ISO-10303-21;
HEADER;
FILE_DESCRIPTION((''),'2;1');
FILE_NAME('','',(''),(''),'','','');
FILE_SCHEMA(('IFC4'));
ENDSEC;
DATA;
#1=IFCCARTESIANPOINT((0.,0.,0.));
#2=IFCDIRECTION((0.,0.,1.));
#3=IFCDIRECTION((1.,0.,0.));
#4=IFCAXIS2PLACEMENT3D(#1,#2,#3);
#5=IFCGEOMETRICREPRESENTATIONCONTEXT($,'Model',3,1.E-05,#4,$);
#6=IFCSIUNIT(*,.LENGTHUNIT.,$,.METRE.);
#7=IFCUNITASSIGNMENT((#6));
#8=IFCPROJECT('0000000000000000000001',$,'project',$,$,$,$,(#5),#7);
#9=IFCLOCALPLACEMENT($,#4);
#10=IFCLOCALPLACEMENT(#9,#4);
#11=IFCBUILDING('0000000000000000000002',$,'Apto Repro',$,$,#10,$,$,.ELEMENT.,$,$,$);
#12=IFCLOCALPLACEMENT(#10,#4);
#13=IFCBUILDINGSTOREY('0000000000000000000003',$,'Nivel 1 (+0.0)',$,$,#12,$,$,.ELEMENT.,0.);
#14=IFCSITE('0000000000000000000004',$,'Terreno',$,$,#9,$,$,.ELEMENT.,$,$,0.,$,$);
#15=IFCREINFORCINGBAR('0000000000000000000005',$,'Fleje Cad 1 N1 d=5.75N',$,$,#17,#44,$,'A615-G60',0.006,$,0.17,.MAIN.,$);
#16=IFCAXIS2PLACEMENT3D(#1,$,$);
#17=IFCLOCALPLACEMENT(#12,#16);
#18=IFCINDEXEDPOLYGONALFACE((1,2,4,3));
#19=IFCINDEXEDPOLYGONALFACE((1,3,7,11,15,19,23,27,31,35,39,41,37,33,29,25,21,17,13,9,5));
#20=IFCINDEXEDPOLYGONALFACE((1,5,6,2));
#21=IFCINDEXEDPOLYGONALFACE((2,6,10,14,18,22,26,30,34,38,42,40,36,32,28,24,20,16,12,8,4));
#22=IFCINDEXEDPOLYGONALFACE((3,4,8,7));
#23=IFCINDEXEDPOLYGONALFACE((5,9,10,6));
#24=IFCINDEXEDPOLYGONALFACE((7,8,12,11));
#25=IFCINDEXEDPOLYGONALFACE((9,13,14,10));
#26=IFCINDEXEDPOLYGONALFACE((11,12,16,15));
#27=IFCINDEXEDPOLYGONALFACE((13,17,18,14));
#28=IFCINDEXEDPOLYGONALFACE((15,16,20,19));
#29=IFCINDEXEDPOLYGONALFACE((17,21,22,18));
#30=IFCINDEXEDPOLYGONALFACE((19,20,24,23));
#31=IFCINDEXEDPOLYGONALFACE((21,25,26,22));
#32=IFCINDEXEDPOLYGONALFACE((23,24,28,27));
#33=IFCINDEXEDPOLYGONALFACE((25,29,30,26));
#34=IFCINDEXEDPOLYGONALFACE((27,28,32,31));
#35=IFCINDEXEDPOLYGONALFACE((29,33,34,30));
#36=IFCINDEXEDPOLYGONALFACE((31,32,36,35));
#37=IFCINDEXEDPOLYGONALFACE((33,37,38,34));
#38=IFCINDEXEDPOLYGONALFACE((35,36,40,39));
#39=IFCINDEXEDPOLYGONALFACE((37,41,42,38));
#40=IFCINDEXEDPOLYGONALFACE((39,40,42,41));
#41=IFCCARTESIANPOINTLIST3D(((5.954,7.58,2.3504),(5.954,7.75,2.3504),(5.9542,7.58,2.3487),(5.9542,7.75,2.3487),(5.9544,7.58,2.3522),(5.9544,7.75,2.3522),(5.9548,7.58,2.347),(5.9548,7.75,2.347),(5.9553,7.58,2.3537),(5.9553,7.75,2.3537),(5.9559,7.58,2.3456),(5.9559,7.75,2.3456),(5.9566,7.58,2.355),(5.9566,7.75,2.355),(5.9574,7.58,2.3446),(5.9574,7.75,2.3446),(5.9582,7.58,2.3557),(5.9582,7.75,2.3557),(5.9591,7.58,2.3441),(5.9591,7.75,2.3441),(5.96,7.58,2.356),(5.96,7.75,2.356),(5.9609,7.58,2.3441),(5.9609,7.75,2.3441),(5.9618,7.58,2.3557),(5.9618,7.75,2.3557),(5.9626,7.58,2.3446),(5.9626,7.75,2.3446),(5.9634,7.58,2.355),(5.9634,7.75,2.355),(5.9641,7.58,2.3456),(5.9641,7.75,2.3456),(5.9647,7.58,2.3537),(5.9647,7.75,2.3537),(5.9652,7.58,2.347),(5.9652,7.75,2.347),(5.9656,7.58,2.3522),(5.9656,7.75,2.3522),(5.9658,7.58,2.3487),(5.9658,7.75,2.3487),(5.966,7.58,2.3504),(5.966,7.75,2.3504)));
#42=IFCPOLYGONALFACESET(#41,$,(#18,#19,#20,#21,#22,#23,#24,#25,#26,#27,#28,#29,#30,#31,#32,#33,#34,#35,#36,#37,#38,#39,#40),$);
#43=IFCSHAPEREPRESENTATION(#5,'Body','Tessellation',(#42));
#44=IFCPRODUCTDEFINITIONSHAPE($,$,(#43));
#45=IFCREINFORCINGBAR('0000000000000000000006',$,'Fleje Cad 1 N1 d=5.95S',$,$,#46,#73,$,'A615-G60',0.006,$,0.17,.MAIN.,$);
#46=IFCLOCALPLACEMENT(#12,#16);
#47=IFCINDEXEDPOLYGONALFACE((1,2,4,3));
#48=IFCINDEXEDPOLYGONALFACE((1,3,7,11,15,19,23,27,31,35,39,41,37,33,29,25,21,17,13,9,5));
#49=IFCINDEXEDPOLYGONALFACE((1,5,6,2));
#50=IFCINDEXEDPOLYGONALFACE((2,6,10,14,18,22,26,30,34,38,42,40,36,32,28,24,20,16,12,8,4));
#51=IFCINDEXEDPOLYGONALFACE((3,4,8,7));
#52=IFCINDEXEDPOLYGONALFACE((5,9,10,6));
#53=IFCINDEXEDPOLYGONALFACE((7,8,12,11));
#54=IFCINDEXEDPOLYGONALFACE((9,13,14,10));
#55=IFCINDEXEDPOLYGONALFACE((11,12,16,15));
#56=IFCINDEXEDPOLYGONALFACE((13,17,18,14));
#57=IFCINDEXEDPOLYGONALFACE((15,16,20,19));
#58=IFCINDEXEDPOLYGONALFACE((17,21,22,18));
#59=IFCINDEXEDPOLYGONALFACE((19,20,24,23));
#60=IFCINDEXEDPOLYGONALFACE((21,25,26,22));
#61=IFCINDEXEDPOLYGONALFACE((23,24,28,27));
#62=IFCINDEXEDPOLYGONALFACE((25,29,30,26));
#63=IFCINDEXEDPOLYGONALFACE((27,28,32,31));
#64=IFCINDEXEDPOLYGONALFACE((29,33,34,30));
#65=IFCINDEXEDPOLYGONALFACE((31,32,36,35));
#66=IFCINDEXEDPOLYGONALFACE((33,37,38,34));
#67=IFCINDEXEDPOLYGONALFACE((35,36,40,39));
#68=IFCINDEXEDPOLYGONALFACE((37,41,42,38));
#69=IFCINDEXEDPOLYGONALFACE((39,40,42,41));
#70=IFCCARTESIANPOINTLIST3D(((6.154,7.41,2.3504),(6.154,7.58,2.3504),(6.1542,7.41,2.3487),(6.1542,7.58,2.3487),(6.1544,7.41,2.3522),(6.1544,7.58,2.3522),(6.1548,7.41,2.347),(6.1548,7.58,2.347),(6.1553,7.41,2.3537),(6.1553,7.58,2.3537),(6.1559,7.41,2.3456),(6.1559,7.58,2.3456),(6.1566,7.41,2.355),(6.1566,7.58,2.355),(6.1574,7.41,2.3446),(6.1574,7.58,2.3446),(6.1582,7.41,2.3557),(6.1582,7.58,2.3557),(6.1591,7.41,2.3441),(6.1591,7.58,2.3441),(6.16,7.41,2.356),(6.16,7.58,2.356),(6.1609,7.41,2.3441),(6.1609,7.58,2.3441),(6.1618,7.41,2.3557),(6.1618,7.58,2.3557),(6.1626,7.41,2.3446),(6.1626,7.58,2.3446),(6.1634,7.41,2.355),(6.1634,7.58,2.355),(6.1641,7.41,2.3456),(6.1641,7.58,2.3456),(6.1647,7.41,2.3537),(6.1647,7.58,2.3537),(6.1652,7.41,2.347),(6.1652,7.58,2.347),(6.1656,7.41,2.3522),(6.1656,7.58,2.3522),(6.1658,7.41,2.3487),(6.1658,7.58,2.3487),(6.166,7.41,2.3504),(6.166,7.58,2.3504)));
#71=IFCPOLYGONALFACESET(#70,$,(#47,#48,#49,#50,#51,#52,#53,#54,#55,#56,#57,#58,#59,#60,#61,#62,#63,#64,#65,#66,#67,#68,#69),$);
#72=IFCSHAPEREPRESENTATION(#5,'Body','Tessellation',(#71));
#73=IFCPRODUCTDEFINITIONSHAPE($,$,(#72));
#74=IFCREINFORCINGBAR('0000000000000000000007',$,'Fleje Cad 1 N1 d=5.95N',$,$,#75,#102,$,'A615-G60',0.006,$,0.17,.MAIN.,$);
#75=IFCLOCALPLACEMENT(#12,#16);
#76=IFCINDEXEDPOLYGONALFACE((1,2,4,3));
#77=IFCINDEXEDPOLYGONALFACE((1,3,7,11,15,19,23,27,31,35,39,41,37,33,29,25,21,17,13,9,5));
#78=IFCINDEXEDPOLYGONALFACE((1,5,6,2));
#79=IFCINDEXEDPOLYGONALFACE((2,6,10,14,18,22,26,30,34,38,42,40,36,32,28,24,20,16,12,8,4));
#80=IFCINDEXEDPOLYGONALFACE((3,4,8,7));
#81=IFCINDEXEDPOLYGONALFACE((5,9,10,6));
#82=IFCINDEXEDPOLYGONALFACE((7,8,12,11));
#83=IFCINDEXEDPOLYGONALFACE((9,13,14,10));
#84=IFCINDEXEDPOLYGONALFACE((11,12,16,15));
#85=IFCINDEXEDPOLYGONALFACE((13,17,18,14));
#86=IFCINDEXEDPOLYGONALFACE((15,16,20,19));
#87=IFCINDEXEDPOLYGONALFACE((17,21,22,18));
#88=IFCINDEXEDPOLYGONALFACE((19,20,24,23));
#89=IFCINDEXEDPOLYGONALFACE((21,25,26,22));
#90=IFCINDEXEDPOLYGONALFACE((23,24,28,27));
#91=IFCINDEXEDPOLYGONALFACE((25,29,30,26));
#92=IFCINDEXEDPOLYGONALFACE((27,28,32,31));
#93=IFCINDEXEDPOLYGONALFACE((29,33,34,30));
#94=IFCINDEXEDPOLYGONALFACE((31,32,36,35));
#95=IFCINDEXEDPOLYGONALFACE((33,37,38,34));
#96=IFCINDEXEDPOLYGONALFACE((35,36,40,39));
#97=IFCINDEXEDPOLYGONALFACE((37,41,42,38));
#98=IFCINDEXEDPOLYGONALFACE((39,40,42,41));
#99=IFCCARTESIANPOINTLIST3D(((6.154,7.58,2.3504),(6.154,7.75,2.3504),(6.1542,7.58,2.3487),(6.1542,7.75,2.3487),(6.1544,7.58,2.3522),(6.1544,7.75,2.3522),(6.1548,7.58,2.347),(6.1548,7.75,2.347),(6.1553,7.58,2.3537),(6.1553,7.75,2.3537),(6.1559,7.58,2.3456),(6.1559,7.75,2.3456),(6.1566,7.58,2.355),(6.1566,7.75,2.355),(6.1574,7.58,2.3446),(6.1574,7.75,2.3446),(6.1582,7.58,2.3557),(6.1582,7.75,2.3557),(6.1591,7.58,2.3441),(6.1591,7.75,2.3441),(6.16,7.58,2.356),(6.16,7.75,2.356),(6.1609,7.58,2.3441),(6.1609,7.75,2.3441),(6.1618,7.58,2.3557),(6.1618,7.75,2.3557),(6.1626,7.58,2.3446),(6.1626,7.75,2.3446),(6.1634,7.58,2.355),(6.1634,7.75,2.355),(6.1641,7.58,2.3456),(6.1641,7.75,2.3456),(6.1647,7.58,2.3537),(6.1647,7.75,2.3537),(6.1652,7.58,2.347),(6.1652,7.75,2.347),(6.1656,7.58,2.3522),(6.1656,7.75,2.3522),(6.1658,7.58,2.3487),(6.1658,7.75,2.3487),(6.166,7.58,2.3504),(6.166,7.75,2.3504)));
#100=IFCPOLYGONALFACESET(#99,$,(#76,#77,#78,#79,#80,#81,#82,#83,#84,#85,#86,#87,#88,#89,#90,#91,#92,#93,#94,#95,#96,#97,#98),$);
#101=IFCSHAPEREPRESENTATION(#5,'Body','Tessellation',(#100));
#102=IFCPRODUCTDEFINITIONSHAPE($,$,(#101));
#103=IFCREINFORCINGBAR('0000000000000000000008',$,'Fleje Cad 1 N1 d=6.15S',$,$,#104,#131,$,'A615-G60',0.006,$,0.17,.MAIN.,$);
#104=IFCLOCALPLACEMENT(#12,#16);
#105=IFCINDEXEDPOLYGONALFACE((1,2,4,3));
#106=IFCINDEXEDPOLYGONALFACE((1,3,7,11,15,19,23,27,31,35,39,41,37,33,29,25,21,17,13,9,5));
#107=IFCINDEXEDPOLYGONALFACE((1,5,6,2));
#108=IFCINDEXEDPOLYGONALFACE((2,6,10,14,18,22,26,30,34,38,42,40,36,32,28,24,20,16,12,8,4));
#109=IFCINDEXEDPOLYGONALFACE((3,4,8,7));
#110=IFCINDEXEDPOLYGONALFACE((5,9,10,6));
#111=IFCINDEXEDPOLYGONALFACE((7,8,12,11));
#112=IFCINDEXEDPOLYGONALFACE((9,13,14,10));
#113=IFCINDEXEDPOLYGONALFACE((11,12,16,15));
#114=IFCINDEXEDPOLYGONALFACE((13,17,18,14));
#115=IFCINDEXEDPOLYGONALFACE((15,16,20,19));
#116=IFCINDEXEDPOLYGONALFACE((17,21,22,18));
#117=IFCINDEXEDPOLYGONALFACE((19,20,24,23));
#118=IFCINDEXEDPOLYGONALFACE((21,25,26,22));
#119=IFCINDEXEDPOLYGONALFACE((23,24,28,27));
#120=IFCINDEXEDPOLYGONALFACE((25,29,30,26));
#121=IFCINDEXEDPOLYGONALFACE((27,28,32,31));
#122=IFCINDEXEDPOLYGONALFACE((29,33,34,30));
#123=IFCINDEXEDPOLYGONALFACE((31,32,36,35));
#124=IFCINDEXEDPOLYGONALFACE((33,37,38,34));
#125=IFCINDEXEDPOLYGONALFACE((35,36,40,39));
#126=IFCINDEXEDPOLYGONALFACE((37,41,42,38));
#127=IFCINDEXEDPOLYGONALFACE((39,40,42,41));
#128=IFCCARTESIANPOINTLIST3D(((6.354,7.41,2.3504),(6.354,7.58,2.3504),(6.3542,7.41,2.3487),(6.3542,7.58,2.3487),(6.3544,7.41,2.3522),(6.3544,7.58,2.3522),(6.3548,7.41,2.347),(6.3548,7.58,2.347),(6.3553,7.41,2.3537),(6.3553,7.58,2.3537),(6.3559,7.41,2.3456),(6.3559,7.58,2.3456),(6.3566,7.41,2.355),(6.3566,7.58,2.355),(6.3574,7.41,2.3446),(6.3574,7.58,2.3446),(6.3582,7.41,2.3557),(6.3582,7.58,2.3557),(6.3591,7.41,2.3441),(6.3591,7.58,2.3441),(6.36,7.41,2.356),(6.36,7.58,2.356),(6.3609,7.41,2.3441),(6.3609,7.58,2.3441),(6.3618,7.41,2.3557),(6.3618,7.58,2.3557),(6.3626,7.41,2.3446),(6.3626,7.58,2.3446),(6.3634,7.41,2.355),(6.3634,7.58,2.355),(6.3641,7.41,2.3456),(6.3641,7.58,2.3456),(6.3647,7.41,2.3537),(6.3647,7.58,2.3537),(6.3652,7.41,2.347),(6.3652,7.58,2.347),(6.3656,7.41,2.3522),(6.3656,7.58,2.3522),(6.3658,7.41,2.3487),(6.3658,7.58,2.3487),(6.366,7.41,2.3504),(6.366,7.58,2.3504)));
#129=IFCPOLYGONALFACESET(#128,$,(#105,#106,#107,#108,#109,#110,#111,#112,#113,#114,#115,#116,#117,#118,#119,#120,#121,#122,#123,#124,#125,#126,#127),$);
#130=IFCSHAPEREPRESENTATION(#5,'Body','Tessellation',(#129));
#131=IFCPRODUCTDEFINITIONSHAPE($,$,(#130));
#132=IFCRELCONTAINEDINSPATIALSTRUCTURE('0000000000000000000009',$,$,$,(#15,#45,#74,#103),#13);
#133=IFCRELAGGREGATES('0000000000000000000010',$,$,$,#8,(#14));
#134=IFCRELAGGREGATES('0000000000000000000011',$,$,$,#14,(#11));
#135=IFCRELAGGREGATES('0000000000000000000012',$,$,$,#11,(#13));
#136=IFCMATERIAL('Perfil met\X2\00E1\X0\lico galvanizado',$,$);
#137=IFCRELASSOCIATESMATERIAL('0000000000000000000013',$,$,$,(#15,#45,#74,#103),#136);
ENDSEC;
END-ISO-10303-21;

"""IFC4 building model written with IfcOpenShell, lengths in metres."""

from ifc_helpers import new_model, si_unit, frame, origin_with_axes, origin_2d_with_axis, place, context, project, spatial, circle, extrude, material, element, save


model = new_model("IFC4")

# Units and contexts
model_context = context("Model", 3, precision=1e-05, world=origin_with_axes())
ifc_project = project(units=[si_unit("LENGTHUNIT", "METRE")], contexts=[model_context])

# Site, building, storey
site_placement = place(None, origin_with_axes())
site = spatial("IfcSite", under=ifc_project, at=site_placement, Name="Terreno", CompositionType="ELEMENT", RefElevation=0.0)
building_placement = place(site_placement, origin_with_axes())
building = spatial("IfcBuilding", under=site, at=building_placement, Name="Apto Repro", CompositionType="ELEMENT")
storey_placement = place(building_placement, origin_with_axes())
storey = spatial("IfcBuildingStorey", under=building, at=storey_placement, Name="Nivel 1 (+0.0)", CompositionType="ELEMENT", Elevation=0.0)

# Reinforcing bars
ifc_material = material(Name="Perfil metálico galvanizado")
reinforcing_bar_1_placement = place(storey_placement, origin_with_axes())
element("IfcReinforcingBar", 1, at=reinforcing_bar_1_placement, inside=storey, material=ifc_material, Name="Fleje Cad 1 N1 d=5.75N", SteelGrade="A615-G60", BarLength=0.17, NominalDiameter=0.006, PredefinedType="MAIN", context=model_context, shape_type="SweptSolid", body=[
    extrude(circle(Radius=0.006, at=origin_2d_with_axis()), frame((5.96, 7.58, 2.35), z_axis=(0.0, 1.0, 0.0), x_axis=(0.0, 0.0, 1.0)), (0.0, 0.0, 1.0), 0.17),
])
reinforcing_bar_2_placement = place(storey_placement, origin_with_axes())
element("IfcReinforcingBar", 2, at=reinforcing_bar_2_placement, inside=storey, material=ifc_material, Name="Fleje Cad 1 N1 d=5.95S", SteelGrade="A615-G60", BarLength=0.17, NominalDiameter=0.006, PredefinedType="MAIN", context=model_context, shape_type="SweptSolid", body=[
    extrude(circle(Radius=0.006, at=origin_2d_with_axis()), frame((6.16, 7.41, 2.35), z_axis=(0.0, 1.0, 0.0), x_axis=(0.0, 0.0, 1.0)), (0.0, 0.0, 1.0), 0.17),
])
reinforcing_bar_3_placement = place(storey_placement, origin_with_axes())
element("IfcReinforcingBar", 3, at=reinforcing_bar_3_placement, inside=storey, material=ifc_material, Name="Fleje Cad 1 N1 d=5.95N", SteelGrade="A615-G60", BarLength=0.17, NominalDiameter=0.006, PredefinedType="MAIN", context=model_context, shape_type="SweptSolid", body=[
    extrude(circle(Radius=0.006, at=origin_2d_with_axis()), frame((6.16, 7.58, 2.35), z_axis=(0.0, 1.0, 0.0), x_axis=(0.0, 0.0, 1.0)), (0.0, 0.0, 1.0), 0.17),
])
reinforcing_bar_4_placement = place(storey_placement, origin_with_axes())
element("IfcReinforcingBar", 4, at=reinforcing_bar_4_placement, inside=storey, material=ifc_material, Name="Fleje Cad 1 N1 d=6.15S", SteelGrade="A615-G60", BarLength=0.17, NominalDiameter=0.006, PredefinedType="MAIN", context=model_context, shape_type="SweptSolid", body=[
    extrude(circle(Radius=0.006, at=origin_2d_with_axis()), frame((6.36, 7.41, 2.35), z_axis=(0.0, 1.0, 0.0), x_axis=(0.0, 0.0, 1.0)), (0.0, 0.0, 1.0), 0.17),
])

save(model, "model.ifc")
